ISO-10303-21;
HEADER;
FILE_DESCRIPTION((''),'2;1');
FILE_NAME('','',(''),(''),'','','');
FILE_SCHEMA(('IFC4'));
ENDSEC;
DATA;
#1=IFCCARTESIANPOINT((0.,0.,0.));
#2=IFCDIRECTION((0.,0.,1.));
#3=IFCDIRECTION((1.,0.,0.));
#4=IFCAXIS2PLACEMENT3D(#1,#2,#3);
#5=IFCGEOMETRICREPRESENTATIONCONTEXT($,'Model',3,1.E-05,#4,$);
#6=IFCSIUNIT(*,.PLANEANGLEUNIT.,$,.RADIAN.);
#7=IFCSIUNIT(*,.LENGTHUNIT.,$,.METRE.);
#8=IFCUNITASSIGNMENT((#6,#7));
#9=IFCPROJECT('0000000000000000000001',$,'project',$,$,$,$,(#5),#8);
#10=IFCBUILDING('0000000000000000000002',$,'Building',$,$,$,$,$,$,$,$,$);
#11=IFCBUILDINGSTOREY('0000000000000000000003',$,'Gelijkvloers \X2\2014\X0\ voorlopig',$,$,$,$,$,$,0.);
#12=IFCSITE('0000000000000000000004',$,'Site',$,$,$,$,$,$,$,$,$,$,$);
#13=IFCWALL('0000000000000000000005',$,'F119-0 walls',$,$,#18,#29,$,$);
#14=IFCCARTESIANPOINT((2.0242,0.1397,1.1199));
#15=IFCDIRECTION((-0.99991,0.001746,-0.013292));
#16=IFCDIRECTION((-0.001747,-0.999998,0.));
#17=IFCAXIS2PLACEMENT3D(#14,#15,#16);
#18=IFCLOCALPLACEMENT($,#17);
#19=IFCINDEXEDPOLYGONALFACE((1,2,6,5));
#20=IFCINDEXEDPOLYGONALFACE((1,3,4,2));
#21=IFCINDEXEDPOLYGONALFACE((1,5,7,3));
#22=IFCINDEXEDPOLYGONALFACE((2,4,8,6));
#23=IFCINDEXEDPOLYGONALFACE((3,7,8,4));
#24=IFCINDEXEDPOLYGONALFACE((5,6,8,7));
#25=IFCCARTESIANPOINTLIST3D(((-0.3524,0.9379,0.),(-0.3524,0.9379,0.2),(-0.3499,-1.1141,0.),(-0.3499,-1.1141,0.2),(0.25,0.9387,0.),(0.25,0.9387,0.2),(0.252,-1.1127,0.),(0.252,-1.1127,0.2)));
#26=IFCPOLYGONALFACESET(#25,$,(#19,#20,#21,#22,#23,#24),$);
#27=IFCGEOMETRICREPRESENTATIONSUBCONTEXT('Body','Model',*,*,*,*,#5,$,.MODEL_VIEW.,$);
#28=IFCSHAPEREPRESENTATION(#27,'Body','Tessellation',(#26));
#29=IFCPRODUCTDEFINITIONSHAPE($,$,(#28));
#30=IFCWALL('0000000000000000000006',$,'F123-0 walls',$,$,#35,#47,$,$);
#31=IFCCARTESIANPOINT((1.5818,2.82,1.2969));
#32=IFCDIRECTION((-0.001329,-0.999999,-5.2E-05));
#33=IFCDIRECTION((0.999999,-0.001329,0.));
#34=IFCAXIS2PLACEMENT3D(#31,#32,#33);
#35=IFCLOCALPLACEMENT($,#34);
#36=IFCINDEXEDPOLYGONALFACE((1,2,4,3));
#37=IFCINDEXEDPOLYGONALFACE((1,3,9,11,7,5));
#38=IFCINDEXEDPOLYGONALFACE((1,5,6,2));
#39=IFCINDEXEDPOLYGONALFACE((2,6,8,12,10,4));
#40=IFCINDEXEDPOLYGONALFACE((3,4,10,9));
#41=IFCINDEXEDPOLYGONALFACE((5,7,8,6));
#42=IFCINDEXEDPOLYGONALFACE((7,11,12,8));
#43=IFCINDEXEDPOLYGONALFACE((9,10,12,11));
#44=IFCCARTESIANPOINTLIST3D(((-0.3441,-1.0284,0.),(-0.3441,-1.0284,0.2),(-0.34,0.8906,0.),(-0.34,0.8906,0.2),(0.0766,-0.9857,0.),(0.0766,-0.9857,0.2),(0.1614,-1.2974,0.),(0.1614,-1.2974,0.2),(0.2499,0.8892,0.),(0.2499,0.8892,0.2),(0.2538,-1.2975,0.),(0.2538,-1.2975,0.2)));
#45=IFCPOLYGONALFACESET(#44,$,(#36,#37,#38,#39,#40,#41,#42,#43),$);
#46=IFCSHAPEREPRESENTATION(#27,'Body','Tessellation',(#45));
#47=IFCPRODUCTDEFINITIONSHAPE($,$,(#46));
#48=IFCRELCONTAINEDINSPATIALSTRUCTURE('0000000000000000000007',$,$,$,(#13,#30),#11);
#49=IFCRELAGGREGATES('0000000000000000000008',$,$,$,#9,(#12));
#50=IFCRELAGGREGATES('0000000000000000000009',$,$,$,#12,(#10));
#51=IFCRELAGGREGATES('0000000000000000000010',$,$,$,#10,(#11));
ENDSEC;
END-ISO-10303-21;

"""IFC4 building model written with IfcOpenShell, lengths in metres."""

from ifc_helpers import new_model, si_unit, frame, origin_with_axes, place, context, subcontext, project, spatial, polyline, outline, extrude, element, save


model = new_model("IFC4")

# Units and contexts
model_context = context("Model", 3, precision=1e-05, world=origin_with_axes())
body_context = subcontext(model_context, "Body", "Model", "MODEL_VIEW")
ifc_project = project(units=[si_unit("PLANEANGLEUNIT", "RADIAN"), si_unit("LENGTHUNIT", "METRE")], contexts=[model_context])

# Site, building, storey
site = spatial("IfcSite", under=ifc_project, Name="Site")
building = spatial("IfcBuilding", under=site, Name="Building")
storey = spatial("IfcBuildingStorey", under=building, Name="Gelijkvloers — voorlopig", Elevation=0.0)

# Walls
wall_1_placement = place(None, frame((2.0242, 0.1397, 1.1199), z_axis=(-0.99991, 0.001746, -0.013292), x_axis=(-0.001747, -0.999998, 0.0)))
element("IfcWall", 1, at=wall_1_placement, inside=storey, Name="F119-0 walls", context=body_context, shape_type="SweptSolid", body=[
    extrude(outline(polyline([(-0.3499, -1.1141), (0.252, -1.1127), (0.25, 0.9387), (-0.3524, 0.9379), (-0.3499, -1.1141)])), origin_with_axes(), (0.0, 0.0, 1.0), 0.2),
])
wall_2_placement = place(None, frame((1.5818, 2.82, 1.2969), z_axis=(-0.001329, -0.999999, -0.000052), x_axis=(0.999999, -0.001329, 0.0)))
element("IfcWall", 2, at=wall_2_placement, inside=storey, Name="F123-0 walls", context=body_context, shape_type="SweptSolid", body=[
    extrude(outline(polyline([(0.1614, -1.2974), (0.2538, -1.2975), (0.2499, 0.8892), (-0.34, 0.8906), (-0.3441, -1.0284), (0.0766, -0.9857), (0.1614, -1.2974)])), origin_with_axes(), (0.0, 0.0, 1.0), 0.2),
])

save(model, "model.ifc")
